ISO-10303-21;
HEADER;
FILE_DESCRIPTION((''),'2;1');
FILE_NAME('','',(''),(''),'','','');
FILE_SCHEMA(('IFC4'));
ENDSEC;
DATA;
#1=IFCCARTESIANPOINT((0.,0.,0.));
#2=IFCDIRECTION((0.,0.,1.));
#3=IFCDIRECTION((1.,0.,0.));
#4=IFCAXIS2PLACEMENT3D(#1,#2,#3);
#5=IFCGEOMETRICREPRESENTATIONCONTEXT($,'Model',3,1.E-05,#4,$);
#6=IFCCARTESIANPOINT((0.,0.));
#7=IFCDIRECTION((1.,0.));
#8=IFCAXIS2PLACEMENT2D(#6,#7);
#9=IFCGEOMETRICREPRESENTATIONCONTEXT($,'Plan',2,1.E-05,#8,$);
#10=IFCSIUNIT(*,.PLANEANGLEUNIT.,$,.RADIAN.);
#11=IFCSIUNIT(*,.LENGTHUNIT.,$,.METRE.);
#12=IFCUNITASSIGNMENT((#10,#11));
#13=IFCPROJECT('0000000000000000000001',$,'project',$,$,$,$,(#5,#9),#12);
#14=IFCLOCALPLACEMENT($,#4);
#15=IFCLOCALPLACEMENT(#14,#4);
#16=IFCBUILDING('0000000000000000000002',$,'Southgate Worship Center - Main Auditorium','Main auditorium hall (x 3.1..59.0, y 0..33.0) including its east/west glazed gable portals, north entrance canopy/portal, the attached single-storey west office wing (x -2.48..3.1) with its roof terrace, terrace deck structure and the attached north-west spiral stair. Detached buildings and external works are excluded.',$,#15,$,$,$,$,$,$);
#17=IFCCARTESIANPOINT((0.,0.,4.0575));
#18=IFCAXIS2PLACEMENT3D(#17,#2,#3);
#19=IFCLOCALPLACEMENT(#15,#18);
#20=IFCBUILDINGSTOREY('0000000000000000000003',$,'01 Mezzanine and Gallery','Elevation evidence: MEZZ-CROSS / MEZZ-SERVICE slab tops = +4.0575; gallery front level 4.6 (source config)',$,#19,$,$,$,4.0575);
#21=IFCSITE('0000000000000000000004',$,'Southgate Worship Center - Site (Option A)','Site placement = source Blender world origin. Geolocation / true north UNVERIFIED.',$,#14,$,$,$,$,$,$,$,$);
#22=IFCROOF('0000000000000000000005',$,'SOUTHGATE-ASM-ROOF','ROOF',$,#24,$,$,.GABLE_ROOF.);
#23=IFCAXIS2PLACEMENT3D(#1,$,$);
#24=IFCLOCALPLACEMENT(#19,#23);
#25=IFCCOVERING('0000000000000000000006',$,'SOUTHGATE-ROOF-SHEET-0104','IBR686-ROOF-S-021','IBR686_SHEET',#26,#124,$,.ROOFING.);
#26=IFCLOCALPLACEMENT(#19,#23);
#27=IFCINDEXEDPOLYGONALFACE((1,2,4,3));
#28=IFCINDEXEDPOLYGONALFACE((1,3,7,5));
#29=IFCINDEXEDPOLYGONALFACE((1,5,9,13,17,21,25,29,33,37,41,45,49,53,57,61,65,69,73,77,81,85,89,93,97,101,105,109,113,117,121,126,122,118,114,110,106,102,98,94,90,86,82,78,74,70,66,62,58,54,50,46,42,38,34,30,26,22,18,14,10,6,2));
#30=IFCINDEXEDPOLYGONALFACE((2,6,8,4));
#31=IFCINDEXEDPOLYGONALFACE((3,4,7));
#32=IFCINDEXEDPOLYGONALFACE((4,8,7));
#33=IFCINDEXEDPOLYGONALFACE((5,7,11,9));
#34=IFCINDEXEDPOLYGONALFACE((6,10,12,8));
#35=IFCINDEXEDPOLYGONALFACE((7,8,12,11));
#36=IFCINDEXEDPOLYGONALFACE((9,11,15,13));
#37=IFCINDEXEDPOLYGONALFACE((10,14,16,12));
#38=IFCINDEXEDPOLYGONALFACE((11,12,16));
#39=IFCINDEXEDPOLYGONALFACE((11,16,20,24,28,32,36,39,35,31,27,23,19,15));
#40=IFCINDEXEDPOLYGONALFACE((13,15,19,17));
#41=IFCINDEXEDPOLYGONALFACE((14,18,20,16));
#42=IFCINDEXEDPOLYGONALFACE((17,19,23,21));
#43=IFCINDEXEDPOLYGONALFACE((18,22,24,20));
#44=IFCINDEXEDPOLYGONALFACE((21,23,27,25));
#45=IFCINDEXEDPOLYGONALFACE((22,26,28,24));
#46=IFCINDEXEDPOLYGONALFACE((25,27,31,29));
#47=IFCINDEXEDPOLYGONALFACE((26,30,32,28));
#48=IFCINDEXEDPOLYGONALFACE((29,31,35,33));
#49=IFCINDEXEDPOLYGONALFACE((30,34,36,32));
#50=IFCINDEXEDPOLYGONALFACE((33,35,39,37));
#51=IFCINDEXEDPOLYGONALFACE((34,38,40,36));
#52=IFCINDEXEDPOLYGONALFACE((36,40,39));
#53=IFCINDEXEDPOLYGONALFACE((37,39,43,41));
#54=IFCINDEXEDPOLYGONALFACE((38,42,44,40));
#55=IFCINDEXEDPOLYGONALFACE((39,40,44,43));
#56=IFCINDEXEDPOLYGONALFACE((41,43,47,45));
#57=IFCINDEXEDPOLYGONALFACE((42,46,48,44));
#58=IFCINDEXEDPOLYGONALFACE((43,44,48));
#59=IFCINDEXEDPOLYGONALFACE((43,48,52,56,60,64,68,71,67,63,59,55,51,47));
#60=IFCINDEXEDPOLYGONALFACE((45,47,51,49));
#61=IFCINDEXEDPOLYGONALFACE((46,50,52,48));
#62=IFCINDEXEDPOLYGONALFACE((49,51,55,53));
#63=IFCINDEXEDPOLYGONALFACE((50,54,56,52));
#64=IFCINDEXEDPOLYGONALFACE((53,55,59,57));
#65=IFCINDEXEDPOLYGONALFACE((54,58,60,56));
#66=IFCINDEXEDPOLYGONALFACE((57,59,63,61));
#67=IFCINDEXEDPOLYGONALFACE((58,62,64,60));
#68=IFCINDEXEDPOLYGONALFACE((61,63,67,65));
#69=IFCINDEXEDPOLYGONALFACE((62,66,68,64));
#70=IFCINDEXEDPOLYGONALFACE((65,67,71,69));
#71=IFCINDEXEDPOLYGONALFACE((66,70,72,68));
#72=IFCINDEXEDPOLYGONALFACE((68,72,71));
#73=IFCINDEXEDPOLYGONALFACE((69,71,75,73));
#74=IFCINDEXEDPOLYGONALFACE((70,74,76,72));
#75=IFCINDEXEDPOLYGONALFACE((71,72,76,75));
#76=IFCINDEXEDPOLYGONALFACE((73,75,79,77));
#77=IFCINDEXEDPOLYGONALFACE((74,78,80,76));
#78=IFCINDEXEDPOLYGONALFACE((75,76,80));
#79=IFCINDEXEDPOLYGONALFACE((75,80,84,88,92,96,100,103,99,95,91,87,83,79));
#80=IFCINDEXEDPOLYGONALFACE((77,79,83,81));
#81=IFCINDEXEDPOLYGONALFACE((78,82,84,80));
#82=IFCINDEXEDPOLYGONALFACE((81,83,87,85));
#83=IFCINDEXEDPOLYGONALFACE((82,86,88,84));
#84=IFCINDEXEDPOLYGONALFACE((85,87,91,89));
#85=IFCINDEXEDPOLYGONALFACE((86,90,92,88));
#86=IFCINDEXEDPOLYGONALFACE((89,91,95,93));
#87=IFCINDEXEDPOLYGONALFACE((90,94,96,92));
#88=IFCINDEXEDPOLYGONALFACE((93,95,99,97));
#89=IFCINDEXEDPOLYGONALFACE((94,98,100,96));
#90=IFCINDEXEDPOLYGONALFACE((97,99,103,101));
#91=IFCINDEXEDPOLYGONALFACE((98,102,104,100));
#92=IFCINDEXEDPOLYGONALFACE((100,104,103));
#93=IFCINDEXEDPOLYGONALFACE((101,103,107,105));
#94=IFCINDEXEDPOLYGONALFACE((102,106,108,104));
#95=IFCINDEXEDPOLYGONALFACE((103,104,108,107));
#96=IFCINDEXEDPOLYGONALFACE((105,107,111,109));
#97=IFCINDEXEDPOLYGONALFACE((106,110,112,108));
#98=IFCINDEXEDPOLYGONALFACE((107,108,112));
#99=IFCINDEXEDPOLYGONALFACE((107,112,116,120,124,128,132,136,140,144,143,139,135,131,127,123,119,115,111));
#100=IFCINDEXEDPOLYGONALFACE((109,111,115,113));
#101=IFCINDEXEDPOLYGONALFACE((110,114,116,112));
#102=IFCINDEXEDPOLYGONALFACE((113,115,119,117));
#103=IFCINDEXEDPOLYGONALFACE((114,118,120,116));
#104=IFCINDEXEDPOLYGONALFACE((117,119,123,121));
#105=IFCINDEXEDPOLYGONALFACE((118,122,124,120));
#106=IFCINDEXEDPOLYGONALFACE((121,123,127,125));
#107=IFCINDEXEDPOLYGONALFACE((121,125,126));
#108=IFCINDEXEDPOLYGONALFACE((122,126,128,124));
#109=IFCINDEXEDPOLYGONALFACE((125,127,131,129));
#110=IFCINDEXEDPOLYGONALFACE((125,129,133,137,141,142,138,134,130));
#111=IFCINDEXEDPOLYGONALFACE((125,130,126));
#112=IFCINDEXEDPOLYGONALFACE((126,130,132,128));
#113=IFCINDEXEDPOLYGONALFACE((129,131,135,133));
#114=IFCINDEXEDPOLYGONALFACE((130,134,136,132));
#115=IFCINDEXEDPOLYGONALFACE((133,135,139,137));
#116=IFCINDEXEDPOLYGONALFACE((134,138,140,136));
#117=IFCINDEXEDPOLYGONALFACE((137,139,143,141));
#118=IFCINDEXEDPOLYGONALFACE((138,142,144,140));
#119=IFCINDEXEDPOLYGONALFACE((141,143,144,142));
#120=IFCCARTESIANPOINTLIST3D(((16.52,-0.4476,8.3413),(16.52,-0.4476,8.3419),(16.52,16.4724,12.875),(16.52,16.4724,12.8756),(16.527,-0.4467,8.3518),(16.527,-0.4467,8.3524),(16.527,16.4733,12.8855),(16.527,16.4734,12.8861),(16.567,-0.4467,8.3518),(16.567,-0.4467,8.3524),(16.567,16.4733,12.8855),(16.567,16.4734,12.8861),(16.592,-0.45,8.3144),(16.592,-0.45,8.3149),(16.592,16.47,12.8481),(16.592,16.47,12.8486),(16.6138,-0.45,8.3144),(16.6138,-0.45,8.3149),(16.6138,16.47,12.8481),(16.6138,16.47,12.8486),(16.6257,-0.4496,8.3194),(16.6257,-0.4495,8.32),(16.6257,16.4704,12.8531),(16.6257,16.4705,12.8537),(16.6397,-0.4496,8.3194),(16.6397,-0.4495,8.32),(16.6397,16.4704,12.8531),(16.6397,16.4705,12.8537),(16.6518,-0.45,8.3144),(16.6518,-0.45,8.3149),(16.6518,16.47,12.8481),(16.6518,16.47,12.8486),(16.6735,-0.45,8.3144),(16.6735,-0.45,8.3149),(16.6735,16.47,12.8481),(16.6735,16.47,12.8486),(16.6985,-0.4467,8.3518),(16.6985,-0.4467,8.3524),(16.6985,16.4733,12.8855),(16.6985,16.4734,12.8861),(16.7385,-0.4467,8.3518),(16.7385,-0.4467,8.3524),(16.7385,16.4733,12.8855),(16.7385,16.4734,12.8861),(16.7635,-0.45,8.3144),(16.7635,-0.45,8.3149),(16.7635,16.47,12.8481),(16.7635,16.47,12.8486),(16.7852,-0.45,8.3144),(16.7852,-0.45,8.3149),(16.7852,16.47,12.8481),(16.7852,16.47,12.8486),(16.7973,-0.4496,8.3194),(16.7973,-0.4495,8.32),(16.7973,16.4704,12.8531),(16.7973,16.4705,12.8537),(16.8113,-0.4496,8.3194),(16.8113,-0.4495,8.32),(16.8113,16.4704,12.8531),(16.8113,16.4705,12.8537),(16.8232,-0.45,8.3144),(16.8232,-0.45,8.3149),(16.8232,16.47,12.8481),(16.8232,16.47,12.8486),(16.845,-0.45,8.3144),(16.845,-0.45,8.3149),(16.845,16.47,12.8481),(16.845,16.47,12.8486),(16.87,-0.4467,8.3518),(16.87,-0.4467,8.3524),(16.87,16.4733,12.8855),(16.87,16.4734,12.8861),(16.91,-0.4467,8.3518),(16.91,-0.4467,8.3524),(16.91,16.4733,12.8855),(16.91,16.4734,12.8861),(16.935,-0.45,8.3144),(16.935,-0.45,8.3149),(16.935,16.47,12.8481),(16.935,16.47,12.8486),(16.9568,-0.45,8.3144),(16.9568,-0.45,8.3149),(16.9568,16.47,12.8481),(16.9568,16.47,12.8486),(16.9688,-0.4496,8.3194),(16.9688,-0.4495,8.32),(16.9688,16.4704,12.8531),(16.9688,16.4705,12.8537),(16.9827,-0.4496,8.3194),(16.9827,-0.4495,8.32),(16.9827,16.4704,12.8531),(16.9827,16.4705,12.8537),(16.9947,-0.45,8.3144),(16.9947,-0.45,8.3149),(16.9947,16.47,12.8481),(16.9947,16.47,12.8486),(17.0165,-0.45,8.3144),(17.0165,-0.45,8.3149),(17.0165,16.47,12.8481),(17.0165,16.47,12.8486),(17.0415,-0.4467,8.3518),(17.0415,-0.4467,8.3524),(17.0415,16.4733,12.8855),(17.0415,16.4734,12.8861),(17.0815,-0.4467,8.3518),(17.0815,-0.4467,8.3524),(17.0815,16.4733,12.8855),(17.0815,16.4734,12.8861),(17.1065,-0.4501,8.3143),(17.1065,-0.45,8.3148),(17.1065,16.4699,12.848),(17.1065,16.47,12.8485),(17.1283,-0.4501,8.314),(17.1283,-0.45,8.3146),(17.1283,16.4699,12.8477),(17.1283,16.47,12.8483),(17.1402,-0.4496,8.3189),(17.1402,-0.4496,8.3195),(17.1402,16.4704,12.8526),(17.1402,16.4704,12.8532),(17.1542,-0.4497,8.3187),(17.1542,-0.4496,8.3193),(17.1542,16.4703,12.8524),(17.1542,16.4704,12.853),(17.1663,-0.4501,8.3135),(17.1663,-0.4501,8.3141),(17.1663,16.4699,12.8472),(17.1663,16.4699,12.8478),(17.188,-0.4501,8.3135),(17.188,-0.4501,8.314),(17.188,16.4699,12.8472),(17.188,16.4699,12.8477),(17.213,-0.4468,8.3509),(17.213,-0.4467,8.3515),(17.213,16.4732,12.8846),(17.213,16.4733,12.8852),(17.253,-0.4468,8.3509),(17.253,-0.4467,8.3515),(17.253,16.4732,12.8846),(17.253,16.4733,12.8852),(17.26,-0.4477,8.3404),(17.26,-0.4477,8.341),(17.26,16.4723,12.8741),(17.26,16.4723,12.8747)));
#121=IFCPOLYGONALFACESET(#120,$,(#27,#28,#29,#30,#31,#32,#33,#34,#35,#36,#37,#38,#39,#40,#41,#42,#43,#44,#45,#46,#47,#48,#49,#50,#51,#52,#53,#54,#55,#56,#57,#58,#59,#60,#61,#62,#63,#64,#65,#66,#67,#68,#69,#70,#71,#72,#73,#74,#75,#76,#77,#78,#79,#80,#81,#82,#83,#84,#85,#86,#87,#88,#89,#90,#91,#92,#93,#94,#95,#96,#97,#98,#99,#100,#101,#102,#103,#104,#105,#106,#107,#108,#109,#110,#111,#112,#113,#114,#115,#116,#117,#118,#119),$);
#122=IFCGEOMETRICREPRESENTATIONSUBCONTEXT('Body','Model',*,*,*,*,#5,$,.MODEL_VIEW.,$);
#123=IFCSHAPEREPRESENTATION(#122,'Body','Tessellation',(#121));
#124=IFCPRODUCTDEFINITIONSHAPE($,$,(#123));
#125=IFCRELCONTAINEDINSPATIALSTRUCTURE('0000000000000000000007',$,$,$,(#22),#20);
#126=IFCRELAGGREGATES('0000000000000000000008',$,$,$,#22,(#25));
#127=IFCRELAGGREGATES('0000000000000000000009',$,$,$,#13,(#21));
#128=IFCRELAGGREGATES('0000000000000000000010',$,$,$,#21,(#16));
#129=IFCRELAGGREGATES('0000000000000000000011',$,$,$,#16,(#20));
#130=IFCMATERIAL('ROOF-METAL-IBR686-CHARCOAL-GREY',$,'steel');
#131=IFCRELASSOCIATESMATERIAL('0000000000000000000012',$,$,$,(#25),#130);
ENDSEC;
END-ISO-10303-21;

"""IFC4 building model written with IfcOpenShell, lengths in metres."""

from ifc_helpers import new_model, si_unit, frame, origin_with_axes, origin_2d_with_axis, place, context, subcontext, project, spatial, indexed_curve, outline, extrude, clip, halfspace, material, element, aggregate, save


model = new_model("IFC4")

# Units and contexts
model_context = context("Model", 3, precision=1e-05, world=origin_with_axes())
plan_context = context("Plan", 2, precision=1e-05, world=origin_2d_with_axis())
body_context = subcontext(model_context, "Body", "Model", "MODEL_VIEW")
ifc_project = project(units=[si_unit("PLANEANGLEUNIT", "RADIAN"), si_unit("LENGTHUNIT", "METRE")], contexts=[model_context, plan_context])

# Site, building, storey
site_placement = place(None, origin_with_axes())
site = spatial("IfcSite", under=ifc_project, at=site_placement, Name="Southgate Worship Center - Site (Option A)", Description="Site placement = source Blender world origin. Geolocation / true north UNVERIFIED.")
building_placement = place(site_placement, origin_with_axes())
building = spatial("IfcBuilding", under=site, at=building_placement, Name="Southgate Worship Center - Main Auditorium", Description="Main auditorium hall (x 3.1..59.0, y 0..33.0) including its east/west glazed gable portals, north entrance canopy/portal, the attached single-storey west office wing (x -2.48..3.1) with its roof terrace, terrace deck structure and the attached north-west spiral stair. Detached buildings and external works are excluded.")
storey_placement = place(building_placement, frame((0.0, 0.0, 4.0575), z_axis=(0.0, 0.0, 1.0), x_axis=(1.0, 0.0, 0.0)))
storey = spatial("IfcBuildingStorey", under=building, at=storey_placement, Name="01 Mezzanine and Gallery", Description="Elevation evidence: MEZZ-CROSS / MEZZ-SERVICE slab tops = +4.0575; gallery front level 4.6 (source config)", Elevation=4.0575)

# Roof, covering
roof_placement = place(storey_placement, origin_with_axes())
roof = element("IfcRoof", 1, at=roof_placement, inside=storey, Name="SOUTHGATE-ASM-ROOF", Description="ROOF", PredefinedType="GABLE_ROOF")
ifc_material_1 = material(Name="ROOF-METAL-IBR686-CHARCOAL-GREY", Category="steel")
covering_1_placement = place(roof_placement, frame((16.52, -0.4501, 8.3135), z_axis=(0.0, 0.0, 1.0), x_axis=(1.0, 0.0, 0.0)))
covering_1 = element("IfcCovering", 2, at=covering_1_placement, material=ifc_material_1, Name="SOUTHGATE-ROOF-SHEET-0104", Description="IBR686-ROOF-S-021", ObjectType="IBR686_SHEET", PredefinedType="ROOFING", context=body_context, shape_type="Clipping", body=[
    clip(clip(extrude(outline(indexed_curve([(0.0, 0.0), (0.025, 0.0353), (0.065, 0.0353), (0.072, 0.0254), (0.072, 0.0259), (0.065, 0.0358), (0.025, 0.0358), (0.0, 0.0005), (-0.0218, 0.0005), (-0.0338, 0.0053), (-0.0478, 0.0053), (-0.0598, 0.0005), (-0.0815, 0.0005), (-0.1065, 0.0358), (-0.1465, 0.0358), (-0.1715, 0.0005), (-0.1933, 0.0005), (-0.2053, 0.0053), (-0.2193, 0.0053), (-0.2313, 0.0005), (-0.253, 0.0005), (-0.278, 0.0358), (-0.318, 0.0358), (-0.343, 0.0005), (-0.3648, 0.0005), (-0.3768, 0.0053), (-0.3908, 0.0053), (-0.4028, 0.0005), (-0.4245, 0.0005), (-0.4495, 0.0358), (-0.4895, 0.0358), (-0.5145, 0.0004), (-0.5363, 0.0002), (-0.5483, 0.0048), (-0.5623, 0.0046), (-0.5743, -0.0003), (-0.596, -0.0004), (-0.621, 0.0349), (-0.661, 0.0349), (-0.668, 0.0251), (-0.668, 0.0246), (-0.661, 0.0344), (-0.621, 0.0344), (-0.596, -0.0009), (-0.5743, -0.0008), (-0.5623, 0.0041), (-0.5483, 0.0043), (-0.5363, -0.0003), (-0.5145, -0.0001), (-0.4895, 0.0353), (-0.4495, 0.0353), (-0.4245, 0.0), (-0.4028, 0.0), (-0.3908, 0.0048), (-0.3768, 0.0048), (-0.3648, 0.0), (-0.343, 0.0), (-0.318, 0.0353), (-0.278, 0.0353), (-0.253, 0.0), (-0.2313, 0.0), (-0.2193, 0.0048), (-0.2053, 0.0048), (-0.1933, 0.0), (-0.1715, 0.0), (-0.1465, 0.0353), (-0.1065, 0.0353), (-0.0815, 0.0), (-0.0598, 0.0), (-0.0478, 0.0048), (-0.0338, 0.0048), (-0.0218, 0.0), (0.0, 0.0)], self_intersect=False)), frame((0.072, -0.0003, 0.0008), z_axis=(0.0, 0.965926, 0.258819), x_axis=(-1.0, 0.0, 0.0)), (0.0, 0.0, 1.0), 17.5303), halfspace(frame((0.37, 0.0012, 0.014), z_axis=(0.0, -0.996022, 0.089113), x_axis=(1.0, 0.0, 0.0)), False)), halfspace(frame((0.37, 16.9212, 4.5477), z_axis=(0.0, 0.996021, -0.089119), x_axis=(-1.0, 0.0, 0.0)), False)),
])
aggregate(roof, [covering_1])

save(model, "model.ifc")
